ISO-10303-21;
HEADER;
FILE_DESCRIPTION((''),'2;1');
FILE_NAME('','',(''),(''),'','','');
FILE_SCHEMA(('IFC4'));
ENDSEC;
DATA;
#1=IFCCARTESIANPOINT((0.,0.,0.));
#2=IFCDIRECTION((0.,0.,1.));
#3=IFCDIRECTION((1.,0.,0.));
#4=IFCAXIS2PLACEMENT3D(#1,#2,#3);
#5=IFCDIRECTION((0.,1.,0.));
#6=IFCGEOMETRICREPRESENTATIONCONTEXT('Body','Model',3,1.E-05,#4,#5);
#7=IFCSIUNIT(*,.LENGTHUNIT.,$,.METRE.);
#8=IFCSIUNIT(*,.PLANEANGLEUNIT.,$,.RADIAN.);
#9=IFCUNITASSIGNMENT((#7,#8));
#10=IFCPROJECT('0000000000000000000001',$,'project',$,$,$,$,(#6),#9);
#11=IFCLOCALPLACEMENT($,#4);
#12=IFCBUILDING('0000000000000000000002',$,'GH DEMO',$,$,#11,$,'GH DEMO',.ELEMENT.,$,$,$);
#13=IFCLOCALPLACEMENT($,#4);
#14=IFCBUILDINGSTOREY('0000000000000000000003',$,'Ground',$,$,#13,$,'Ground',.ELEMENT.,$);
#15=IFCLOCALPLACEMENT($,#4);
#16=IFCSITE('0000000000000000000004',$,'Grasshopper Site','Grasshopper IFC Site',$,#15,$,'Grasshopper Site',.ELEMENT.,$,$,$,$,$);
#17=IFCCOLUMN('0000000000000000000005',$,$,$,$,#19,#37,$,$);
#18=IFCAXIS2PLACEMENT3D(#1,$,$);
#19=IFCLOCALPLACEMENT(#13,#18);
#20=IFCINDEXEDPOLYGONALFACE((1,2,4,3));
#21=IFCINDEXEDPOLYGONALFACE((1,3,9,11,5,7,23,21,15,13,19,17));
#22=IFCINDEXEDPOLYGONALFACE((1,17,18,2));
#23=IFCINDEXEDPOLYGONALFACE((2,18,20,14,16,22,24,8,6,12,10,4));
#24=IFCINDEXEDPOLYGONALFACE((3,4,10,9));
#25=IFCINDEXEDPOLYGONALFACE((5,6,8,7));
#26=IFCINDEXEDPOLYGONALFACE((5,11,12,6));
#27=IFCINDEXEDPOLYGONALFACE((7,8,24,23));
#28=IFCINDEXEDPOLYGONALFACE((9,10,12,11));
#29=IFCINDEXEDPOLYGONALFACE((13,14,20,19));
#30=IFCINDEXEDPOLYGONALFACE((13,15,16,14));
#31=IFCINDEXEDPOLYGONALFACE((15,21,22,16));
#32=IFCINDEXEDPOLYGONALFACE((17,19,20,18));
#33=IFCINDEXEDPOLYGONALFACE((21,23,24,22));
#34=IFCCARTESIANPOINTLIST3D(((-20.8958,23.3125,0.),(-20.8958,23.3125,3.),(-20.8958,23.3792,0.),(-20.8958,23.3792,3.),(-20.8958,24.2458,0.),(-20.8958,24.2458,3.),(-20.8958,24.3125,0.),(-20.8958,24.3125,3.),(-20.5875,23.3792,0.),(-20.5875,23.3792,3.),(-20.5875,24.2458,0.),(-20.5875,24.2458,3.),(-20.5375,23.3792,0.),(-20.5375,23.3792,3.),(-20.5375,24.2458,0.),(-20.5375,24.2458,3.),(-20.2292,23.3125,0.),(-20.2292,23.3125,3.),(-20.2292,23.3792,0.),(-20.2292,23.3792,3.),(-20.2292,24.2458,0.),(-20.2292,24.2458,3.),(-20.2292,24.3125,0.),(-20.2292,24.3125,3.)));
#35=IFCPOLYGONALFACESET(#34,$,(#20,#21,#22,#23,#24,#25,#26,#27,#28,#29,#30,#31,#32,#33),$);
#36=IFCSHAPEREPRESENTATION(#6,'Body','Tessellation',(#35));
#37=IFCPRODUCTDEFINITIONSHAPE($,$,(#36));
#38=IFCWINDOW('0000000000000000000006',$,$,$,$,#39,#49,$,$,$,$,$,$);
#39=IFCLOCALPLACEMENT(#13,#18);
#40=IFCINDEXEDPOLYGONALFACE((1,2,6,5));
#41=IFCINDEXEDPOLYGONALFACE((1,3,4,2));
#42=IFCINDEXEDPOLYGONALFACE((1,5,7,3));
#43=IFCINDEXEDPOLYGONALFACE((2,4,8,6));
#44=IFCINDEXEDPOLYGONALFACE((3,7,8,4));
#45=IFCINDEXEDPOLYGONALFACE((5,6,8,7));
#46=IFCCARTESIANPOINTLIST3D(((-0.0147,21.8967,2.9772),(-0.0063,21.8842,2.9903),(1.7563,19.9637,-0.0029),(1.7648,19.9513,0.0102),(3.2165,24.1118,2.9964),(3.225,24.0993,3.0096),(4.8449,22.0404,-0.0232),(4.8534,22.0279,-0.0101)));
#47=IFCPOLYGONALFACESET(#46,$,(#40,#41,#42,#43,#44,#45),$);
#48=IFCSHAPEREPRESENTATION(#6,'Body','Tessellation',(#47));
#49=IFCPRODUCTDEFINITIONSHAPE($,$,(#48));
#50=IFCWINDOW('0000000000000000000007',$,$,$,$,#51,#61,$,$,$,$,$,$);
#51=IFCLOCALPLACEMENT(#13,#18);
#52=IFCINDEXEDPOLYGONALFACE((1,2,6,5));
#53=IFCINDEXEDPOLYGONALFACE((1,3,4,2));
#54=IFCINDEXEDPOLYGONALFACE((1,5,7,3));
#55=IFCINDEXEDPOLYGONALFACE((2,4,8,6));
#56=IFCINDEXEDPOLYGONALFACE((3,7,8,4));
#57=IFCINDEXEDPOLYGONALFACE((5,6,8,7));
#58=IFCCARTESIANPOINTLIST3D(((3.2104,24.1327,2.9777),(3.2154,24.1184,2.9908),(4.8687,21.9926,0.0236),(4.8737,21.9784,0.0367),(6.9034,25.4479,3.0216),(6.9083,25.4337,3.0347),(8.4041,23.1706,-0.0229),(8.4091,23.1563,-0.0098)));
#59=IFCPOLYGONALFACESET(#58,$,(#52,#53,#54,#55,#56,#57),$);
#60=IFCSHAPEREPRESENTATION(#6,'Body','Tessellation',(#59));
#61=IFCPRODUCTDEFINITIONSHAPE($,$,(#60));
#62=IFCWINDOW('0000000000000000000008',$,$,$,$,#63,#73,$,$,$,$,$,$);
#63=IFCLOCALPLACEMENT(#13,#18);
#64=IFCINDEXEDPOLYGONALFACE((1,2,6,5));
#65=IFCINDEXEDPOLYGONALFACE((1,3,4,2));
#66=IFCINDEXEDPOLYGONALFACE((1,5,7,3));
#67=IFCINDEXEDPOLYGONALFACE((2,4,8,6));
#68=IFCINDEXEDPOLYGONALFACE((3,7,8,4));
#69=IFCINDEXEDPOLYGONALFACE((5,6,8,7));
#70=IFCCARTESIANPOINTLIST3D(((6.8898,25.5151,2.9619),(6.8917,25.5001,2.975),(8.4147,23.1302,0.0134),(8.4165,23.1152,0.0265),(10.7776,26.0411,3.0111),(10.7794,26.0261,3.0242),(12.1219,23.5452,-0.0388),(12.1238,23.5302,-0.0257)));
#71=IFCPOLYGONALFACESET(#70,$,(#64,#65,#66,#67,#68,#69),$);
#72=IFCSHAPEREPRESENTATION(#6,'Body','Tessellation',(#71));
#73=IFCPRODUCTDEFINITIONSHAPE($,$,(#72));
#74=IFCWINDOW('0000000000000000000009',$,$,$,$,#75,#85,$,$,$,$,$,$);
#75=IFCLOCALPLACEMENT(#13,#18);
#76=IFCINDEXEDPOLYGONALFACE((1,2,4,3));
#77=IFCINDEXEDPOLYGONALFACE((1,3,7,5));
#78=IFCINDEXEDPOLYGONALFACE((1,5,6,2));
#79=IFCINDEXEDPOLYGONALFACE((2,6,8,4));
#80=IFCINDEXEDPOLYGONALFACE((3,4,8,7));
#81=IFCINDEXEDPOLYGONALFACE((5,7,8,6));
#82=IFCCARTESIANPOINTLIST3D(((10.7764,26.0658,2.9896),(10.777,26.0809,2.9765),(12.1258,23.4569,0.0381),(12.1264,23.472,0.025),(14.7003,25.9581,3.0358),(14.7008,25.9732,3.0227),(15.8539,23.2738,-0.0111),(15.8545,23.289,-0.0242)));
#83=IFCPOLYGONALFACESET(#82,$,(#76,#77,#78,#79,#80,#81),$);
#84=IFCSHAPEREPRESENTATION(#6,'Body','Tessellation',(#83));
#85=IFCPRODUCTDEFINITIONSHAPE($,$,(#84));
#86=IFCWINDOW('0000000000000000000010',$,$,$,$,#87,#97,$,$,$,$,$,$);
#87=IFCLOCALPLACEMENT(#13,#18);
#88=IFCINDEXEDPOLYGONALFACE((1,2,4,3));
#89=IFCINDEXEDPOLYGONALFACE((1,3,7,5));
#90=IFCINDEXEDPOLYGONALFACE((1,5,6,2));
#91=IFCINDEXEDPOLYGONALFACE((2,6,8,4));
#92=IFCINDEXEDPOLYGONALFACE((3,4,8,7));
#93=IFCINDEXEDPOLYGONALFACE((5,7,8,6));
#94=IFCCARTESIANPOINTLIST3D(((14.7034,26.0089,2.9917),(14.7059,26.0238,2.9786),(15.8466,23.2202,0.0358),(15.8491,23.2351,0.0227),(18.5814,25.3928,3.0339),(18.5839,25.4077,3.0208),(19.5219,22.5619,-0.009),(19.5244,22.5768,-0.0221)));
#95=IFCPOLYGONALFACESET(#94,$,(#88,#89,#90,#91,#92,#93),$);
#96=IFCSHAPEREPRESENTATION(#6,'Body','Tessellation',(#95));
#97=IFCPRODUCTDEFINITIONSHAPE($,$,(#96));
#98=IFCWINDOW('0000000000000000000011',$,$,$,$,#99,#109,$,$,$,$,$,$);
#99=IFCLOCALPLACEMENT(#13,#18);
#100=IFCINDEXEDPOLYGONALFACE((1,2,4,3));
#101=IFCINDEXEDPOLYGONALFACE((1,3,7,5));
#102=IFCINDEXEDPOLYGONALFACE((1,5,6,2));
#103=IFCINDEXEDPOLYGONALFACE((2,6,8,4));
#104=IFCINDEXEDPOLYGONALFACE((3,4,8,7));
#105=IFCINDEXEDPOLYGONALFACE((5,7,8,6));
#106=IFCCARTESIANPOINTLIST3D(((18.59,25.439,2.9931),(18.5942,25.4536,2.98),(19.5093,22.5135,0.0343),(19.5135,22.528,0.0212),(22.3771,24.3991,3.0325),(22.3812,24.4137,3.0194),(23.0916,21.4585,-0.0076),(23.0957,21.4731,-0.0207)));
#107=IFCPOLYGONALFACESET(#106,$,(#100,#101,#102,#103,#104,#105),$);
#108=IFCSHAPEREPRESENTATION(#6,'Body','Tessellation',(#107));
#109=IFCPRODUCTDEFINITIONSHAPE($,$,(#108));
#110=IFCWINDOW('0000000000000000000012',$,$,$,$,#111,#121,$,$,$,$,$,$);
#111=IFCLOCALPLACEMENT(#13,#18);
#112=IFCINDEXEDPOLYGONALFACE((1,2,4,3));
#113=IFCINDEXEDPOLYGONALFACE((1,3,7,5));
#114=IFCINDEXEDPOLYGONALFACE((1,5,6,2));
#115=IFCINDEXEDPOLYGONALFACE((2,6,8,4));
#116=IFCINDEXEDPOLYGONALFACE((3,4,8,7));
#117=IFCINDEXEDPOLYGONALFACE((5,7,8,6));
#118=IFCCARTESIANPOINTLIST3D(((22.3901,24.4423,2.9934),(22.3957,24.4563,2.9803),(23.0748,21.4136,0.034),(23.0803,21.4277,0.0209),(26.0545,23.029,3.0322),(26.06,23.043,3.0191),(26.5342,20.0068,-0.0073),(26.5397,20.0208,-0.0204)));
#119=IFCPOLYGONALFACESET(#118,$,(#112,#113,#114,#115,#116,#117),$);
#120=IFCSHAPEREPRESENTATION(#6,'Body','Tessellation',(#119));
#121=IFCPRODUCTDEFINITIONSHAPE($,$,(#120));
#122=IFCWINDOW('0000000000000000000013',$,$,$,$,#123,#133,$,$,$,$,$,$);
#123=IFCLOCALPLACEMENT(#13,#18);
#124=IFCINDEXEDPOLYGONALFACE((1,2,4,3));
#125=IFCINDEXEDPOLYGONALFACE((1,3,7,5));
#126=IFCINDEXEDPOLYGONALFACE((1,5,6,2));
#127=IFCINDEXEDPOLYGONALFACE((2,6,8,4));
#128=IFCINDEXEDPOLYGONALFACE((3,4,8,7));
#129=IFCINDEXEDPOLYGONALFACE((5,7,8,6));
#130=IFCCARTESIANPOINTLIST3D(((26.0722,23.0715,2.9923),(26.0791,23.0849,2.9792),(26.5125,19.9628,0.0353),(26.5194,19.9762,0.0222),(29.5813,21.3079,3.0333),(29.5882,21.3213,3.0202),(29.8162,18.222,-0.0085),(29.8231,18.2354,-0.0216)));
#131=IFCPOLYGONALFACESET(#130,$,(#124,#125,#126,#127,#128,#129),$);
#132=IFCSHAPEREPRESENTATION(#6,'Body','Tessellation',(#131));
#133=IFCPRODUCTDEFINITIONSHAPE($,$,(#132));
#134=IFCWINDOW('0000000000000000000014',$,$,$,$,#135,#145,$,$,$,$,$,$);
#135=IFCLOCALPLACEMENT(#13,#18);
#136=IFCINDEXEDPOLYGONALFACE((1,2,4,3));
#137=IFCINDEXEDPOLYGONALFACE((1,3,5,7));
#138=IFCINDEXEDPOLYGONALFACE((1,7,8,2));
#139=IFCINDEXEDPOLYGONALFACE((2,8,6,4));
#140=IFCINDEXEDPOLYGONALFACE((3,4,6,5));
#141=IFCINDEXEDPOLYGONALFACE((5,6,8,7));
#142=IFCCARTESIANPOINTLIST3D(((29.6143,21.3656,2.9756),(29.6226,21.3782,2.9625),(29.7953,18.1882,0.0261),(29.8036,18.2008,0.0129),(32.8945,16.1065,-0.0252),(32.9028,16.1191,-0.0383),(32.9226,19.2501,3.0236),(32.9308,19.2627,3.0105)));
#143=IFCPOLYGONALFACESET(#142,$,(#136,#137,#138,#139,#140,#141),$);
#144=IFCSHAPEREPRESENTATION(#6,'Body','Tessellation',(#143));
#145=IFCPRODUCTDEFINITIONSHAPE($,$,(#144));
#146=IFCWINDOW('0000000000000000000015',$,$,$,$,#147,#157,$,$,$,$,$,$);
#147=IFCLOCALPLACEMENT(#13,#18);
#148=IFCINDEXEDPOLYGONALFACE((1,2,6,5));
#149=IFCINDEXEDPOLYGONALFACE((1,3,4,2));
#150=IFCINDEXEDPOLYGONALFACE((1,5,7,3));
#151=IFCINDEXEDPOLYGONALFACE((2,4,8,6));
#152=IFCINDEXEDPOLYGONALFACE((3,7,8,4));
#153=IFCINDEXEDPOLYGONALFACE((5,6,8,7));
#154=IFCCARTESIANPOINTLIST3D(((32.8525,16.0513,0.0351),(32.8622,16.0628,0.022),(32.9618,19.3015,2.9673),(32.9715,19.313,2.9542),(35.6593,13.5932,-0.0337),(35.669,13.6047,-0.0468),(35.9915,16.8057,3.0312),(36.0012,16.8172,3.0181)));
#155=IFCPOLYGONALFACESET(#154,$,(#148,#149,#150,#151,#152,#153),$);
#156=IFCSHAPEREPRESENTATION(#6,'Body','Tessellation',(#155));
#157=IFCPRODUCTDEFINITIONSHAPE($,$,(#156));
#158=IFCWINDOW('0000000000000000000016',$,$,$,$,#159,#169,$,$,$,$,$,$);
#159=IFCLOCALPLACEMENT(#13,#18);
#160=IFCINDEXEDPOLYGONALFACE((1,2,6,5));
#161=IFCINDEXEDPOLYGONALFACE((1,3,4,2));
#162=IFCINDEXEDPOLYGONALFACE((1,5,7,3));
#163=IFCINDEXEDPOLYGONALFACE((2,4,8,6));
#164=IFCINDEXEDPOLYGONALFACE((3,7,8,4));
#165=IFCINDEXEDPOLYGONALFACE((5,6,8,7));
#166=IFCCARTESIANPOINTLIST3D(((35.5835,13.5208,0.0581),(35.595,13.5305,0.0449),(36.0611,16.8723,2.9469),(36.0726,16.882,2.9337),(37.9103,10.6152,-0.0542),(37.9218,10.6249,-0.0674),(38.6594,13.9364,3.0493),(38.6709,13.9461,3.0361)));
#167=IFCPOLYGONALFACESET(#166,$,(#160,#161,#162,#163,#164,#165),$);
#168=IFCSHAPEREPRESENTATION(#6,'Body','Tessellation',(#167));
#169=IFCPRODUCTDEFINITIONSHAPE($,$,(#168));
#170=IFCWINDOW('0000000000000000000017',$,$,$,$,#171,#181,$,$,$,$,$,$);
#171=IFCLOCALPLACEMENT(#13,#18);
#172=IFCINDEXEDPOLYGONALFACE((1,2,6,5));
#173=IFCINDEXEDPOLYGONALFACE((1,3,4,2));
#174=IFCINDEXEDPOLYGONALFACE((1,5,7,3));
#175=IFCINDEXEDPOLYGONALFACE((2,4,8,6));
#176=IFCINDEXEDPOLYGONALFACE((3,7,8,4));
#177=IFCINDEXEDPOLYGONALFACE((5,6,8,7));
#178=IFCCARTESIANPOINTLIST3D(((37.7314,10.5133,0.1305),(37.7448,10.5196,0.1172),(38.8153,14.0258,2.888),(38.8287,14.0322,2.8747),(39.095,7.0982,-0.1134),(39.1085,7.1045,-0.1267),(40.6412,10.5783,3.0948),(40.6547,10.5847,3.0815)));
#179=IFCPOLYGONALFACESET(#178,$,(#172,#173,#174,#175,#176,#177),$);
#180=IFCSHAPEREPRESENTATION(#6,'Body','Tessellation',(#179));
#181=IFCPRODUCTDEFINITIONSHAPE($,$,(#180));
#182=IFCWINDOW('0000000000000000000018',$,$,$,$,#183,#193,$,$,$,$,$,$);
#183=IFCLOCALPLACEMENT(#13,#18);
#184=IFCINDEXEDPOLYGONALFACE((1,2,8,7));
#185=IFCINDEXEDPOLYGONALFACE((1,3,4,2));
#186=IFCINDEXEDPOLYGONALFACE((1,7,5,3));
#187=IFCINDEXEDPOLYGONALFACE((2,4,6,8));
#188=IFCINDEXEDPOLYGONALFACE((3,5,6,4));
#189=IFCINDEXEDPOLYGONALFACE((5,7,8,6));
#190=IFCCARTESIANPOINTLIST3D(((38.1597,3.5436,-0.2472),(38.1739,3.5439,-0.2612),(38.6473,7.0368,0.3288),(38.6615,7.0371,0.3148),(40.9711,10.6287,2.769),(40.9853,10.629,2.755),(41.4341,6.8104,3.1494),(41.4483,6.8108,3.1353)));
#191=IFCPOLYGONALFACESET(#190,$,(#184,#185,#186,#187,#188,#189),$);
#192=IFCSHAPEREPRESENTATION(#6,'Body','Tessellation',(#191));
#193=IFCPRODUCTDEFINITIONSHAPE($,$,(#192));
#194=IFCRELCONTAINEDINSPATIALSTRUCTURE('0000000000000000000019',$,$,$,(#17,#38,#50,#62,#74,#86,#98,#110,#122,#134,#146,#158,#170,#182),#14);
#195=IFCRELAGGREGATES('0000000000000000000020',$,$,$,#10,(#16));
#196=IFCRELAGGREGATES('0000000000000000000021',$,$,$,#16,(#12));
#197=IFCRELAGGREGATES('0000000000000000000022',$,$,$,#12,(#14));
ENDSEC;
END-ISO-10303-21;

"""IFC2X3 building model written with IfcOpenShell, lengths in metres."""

from ifc_helpers import new_model, si_unit, direction, frame, origin_with_axes, place, context, project, spatial, polyline, outline, extrude, source, transform, mapped, element, save


model = new_model("IFC2X3")

# Units and contexts
model_context = context("Model", 3, precision=1e-05, world=origin_with_axes(), true_north=direction((0.0, 1.0, 0.0)), identifier="Body")
ifc_project = project(units=[si_unit("LENGTHUNIT", "METRE"), si_unit("PLANEANGLEUNIT", "RADIAN")], contexts=[model_context])

# Site, building, storey
site_placement = place(None, origin_with_axes())
site = spatial("IfcSite", under=ifc_project, at=site_placement, Name="Grasshopper Site", Description="Grasshopper IFC Site", LongName="Grasshopper Site", CompositionType="ELEMENT")
building_placement = place(None, origin_with_axes())
building = spatial("IfcBuilding", under=site, at=building_placement, Name="GH DEMO", LongName="GH DEMO", CompositionType="ELEMENT")
storey_placement = place(None, origin_with_axes())
storey = spatial("IfcBuildingStorey", under=building, at=storey_placement, Name="Ground", LongName="Ground", CompositionType="ELEMENT")

# Column
shared_shape_1 = source(origin_with_axes(), model_context, "Body", "SweptSolid", [
    extrude(outline(polyline([(0.025, -0.4333), (0.025, 0.4333), (0.3333, 0.4333), (0.3333, 0.5), (-0.3333, 0.5), (-0.3333, 0.4333), (-0.025, 0.4333), (-0.025, -0.4333), (-0.3333, -0.4333), (-0.3333, -0.5), (0.3333, -0.5), (0.3333, -0.4333), (0.025, -0.4333)])), origin_with_axes(), (0.0, 0.0, 1.0), 3.0),
])
column_1_placement = place(None, origin_with_axes())
element("IfcColumn", 1, at=column_1_placement, inside=storey, context=model_context, shape_type="MappedRepresentation", body=[
    mapped(shared_shape_1, transform((-20.5625, 23.8125, 0.0), x_axis=(1.0, 0.0, 0.0), y_axis=(0.0, 1.0, 0.0), z_axis=(0.0, 0.0, 1.0), scale=1.0)),
])

# Windows
window_1_placement = place(None, origin_with_axes())
element("IfcWindow", 2, at=window_1_placement, inside=storey, context=model_context, shape_type="SweptSolid", body=[
    extrude(outline(polyline([(0.0, 0.0), (3.9691, 0.0), (3.6205, 3.9021), (-0.3821, 3.7022), (0.0, 0.0)])), frame((1.7648, 19.9513, 0.0102), z_axis=(-0.423819, 0.623938, -0.656566), x_axis=(-0.446205, 0.486995, 0.750824)), (0.0, 0.0, 1.0), 0.02),
])
window_2_placement = place(None, origin_with_axes())
element("IfcWindow", 3, at=window_2_placement, inside=storey, context=model_context, shape_type="SweptSolid", body=[
    extrude(outline(polyline([(0.0, 0.0), (4.0071, 0.0), (3.2136, 3.8393), (-0.8683, 3.6242), (0.0, 0.0)])), frame((4.8687, 21.9926, 0.0236), z_axis=(-0.246456, 0.713864, -0.655483), x_axis=(-0.41384, 0.534065, 0.737232)), (0.0, 0.0, -1.0), 0.02),
])
window_3_placement = place(None, origin_with_axes())
element("IfcWindow", 4, at=window_3_placement, inside=storey, context=model_context, shape_type="SweptSolid", body=[
    extrude(outline(polyline([(0.0, 0.0), (4.0873, 0.0), (2.9793, 3.7638), (-1.1786, 3.5397), (0.0, 0.0)])), frame((8.4165, 23.1152, 0.0265), z_axis=(-0.093182, 0.750002, -0.654839), x_axis=(-0.37307, 0.583484, 0.721364)), (0.0, 0.0, 1.0), 0.02),
])
window_4_placement = place(None, origin_with_axes())
element("IfcWindow", 5, at=window_4_placement, inside=storey, context=model_context, shape_type="SweptSolid", body=[
    extrude(outline(polyline([(0.0, 0.0), (4.1639, 0.0), (2.8577, 3.7019), (-1.3577, 3.4773), (0.0, 0.0)])), frame((12.1264, 23.472, 0.025), z_axis=(0.028451, 0.755376, -0.654674), x_axis=(-0.324054, 0.626538, 0.70883)), (0.0, 0.0, -1.0), 0.02),
])
window_5_placement = place(None, origin_with_axes())
element("IfcWindow", 6, at=window_5_placement, inside=storey, context=model_context, shape_type="SweptSolid", body=[
    extrude(outline(polyline([(0.0, 0.0), (4.2214, 0.0), (2.7939, 3.6581), (-1.4616, 3.4362), (0.0, 0.0)])), frame((15.8491, 23.2351, 0.0227), z_axis=(0.125531, 0.745402, -0.654689), x_axis=(-0.270796, 0.660595, 0.700203)), (0.0, 0.0, -1.0), 0.02),
])
window_6_placement = place(None, origin_with_axes())
element("IfcWindow", 7, at=window_6_placement, inside=storey, context=model_context, shape_type="SweptSolid", body=[
    extrude(outline(polyline([(0.0, 0.0), (4.2613, 0.0), (2.7577, 3.6282), (-1.5262, 3.4085), (0.0, 0.0)])), frame((19.5135, 22.528, 0.0212), z_axis=(0.206466, 0.727086, -0.654765), x_axis=(-0.215735, 0.686543, 0.694347)), (0.0, 0.0, -1.0), 0.02),
])
window_7_placement = place(None, origin_with_axes())
element("IfcWindow", 8, at=window_7_placement, inside=storey, context=model_context, shape_type="SweptSolid", body=[
    extrude(outline(polyline([(0.0, 0.0), (4.2895, 0.0), (2.7335, 3.6063), (-1.5739, 3.3869), (0.0, 0.0)])), frame((23.0803, 21.4277, 0.0209), z_axis=(0.277978, 0.702753, -0.654879), x_axis=(-0.159614, 0.706062, 0.689927)), (0.0, 0.0, -1.0), 0.02),
])
window_8_placement = place(None, origin_with_axes())
element("IfcWindow", 9, at=window_8_placement, inside=storey, context=model_context, shape_type="SweptSolid", body=[
    extrude(outline(polyline([(0.0, 0.0), (4.3129, 0.0), (2.7117, 3.5864), (-1.622, 3.3639), (0.0, 0.0)])), frame((26.5194, 19.9762, 0.0222), z_axis=(0.34541, 0.672005, -0.655058), x_axis=(-0.102078, 0.720782, 0.685604)), (0.0, 0.0, -1.0), 0.02),
])
window_9_placement = place(None, origin_with_axes())
element("IfcWindow", 10, at=window_9_placement, inside=storey, context=model_context, shape_type="SweptSolid", body=[
    extrude(outline(polyline([(0.0, 0.0), (4.3392, 0.0), (2.6847, 3.5616), (-1.6885, 3.3302), (0.0, 0.0)])), frame((29.7953, 18.1882, 0.0261), z_axis=(0.413629, 0.631953, -0.655398), x_axis=(-0.041706, 0.732262, 0.679745)), (0.0, 0.0, 1.0), 0.02),
])
window_10_placement = place(None, origin_with_axes())
element("IfcWindow", 11, at=window_10_placement, inside=storey, context=model_context, shape_type="SweptSolid", body=[
    extrude(outline(polyline([(0.0, 0.0), (4.3787, 0.0), (2.6446, 3.5221), (-1.8006, 3.2685), (0.0, 0.0)])), frame((32.8525, 16.0513, 0.0351), z_axis=(0.487988, 0.575572, -0.656189), x_axis=(0.024965, 0.742267, 0.66964)), (0.0, 0.0, 1.0), 0.02),
])
window_11_placement = place(None, origin_with_axes())
element("IfcWindow", 12, at=window_11_placement, inside=storey, context=model_context, shape_type="SweptSolid", body=[
    extrude(outline(polyline([(0.0, 0.0), (4.4504, 0.0), (2.5847, 3.4497), (-2.0114, 3.1342), (0.0, 0.0)])), frame((35.5835, 13.5208, 0.0581), z_axis=(0.574794, 0.485726, -0.658545), x_axis=(0.107304, 0.753085, 0.649114)), (0.0, 0.0, 1.0), 0.02),
])
window_12_placement = place(None, origin_with_axes())
element("IfcWindow", 13, at=window_12_placement, inside=storey, context=model_context, shape_type="SweptSolid", body=[
    extrude(outline(polyline([(0.0, 0.0), (4.5953, 0.0), (2.5149, 3.3067), (-2.4351, 2.7662), (0.0, 0.0)])), frame((37.7314, 10.5133, 0.1305), z_axis=(0.673439, 0.31661, -0.66801), x_axis=(0.235871, 0.76438, 0.600073)), (0.0, 0.0, 1.0), 0.02),
])
window_13_placement = place(None, origin_with_axes())
element("IfcWindow", 14, at=window_13_placement, inside=storey, context=model_context, shape_type="SweptSolid", body=[
    extrude(outline(polyline([(0.0, 0.0), (4.925, 0.0), (2.5473, 3.047), (-3.0631, 1.8411), (0.0, 0.0)])), frame((38.6473, 7.0368, 0.3288), z_axis=(0.711914, 0.016394, -0.702076), x_axis=(0.471826, 0.72931, 0.495467)), (0.0, 0.0, 1.0), 0.02),
])

save(model, "model.ifc")
